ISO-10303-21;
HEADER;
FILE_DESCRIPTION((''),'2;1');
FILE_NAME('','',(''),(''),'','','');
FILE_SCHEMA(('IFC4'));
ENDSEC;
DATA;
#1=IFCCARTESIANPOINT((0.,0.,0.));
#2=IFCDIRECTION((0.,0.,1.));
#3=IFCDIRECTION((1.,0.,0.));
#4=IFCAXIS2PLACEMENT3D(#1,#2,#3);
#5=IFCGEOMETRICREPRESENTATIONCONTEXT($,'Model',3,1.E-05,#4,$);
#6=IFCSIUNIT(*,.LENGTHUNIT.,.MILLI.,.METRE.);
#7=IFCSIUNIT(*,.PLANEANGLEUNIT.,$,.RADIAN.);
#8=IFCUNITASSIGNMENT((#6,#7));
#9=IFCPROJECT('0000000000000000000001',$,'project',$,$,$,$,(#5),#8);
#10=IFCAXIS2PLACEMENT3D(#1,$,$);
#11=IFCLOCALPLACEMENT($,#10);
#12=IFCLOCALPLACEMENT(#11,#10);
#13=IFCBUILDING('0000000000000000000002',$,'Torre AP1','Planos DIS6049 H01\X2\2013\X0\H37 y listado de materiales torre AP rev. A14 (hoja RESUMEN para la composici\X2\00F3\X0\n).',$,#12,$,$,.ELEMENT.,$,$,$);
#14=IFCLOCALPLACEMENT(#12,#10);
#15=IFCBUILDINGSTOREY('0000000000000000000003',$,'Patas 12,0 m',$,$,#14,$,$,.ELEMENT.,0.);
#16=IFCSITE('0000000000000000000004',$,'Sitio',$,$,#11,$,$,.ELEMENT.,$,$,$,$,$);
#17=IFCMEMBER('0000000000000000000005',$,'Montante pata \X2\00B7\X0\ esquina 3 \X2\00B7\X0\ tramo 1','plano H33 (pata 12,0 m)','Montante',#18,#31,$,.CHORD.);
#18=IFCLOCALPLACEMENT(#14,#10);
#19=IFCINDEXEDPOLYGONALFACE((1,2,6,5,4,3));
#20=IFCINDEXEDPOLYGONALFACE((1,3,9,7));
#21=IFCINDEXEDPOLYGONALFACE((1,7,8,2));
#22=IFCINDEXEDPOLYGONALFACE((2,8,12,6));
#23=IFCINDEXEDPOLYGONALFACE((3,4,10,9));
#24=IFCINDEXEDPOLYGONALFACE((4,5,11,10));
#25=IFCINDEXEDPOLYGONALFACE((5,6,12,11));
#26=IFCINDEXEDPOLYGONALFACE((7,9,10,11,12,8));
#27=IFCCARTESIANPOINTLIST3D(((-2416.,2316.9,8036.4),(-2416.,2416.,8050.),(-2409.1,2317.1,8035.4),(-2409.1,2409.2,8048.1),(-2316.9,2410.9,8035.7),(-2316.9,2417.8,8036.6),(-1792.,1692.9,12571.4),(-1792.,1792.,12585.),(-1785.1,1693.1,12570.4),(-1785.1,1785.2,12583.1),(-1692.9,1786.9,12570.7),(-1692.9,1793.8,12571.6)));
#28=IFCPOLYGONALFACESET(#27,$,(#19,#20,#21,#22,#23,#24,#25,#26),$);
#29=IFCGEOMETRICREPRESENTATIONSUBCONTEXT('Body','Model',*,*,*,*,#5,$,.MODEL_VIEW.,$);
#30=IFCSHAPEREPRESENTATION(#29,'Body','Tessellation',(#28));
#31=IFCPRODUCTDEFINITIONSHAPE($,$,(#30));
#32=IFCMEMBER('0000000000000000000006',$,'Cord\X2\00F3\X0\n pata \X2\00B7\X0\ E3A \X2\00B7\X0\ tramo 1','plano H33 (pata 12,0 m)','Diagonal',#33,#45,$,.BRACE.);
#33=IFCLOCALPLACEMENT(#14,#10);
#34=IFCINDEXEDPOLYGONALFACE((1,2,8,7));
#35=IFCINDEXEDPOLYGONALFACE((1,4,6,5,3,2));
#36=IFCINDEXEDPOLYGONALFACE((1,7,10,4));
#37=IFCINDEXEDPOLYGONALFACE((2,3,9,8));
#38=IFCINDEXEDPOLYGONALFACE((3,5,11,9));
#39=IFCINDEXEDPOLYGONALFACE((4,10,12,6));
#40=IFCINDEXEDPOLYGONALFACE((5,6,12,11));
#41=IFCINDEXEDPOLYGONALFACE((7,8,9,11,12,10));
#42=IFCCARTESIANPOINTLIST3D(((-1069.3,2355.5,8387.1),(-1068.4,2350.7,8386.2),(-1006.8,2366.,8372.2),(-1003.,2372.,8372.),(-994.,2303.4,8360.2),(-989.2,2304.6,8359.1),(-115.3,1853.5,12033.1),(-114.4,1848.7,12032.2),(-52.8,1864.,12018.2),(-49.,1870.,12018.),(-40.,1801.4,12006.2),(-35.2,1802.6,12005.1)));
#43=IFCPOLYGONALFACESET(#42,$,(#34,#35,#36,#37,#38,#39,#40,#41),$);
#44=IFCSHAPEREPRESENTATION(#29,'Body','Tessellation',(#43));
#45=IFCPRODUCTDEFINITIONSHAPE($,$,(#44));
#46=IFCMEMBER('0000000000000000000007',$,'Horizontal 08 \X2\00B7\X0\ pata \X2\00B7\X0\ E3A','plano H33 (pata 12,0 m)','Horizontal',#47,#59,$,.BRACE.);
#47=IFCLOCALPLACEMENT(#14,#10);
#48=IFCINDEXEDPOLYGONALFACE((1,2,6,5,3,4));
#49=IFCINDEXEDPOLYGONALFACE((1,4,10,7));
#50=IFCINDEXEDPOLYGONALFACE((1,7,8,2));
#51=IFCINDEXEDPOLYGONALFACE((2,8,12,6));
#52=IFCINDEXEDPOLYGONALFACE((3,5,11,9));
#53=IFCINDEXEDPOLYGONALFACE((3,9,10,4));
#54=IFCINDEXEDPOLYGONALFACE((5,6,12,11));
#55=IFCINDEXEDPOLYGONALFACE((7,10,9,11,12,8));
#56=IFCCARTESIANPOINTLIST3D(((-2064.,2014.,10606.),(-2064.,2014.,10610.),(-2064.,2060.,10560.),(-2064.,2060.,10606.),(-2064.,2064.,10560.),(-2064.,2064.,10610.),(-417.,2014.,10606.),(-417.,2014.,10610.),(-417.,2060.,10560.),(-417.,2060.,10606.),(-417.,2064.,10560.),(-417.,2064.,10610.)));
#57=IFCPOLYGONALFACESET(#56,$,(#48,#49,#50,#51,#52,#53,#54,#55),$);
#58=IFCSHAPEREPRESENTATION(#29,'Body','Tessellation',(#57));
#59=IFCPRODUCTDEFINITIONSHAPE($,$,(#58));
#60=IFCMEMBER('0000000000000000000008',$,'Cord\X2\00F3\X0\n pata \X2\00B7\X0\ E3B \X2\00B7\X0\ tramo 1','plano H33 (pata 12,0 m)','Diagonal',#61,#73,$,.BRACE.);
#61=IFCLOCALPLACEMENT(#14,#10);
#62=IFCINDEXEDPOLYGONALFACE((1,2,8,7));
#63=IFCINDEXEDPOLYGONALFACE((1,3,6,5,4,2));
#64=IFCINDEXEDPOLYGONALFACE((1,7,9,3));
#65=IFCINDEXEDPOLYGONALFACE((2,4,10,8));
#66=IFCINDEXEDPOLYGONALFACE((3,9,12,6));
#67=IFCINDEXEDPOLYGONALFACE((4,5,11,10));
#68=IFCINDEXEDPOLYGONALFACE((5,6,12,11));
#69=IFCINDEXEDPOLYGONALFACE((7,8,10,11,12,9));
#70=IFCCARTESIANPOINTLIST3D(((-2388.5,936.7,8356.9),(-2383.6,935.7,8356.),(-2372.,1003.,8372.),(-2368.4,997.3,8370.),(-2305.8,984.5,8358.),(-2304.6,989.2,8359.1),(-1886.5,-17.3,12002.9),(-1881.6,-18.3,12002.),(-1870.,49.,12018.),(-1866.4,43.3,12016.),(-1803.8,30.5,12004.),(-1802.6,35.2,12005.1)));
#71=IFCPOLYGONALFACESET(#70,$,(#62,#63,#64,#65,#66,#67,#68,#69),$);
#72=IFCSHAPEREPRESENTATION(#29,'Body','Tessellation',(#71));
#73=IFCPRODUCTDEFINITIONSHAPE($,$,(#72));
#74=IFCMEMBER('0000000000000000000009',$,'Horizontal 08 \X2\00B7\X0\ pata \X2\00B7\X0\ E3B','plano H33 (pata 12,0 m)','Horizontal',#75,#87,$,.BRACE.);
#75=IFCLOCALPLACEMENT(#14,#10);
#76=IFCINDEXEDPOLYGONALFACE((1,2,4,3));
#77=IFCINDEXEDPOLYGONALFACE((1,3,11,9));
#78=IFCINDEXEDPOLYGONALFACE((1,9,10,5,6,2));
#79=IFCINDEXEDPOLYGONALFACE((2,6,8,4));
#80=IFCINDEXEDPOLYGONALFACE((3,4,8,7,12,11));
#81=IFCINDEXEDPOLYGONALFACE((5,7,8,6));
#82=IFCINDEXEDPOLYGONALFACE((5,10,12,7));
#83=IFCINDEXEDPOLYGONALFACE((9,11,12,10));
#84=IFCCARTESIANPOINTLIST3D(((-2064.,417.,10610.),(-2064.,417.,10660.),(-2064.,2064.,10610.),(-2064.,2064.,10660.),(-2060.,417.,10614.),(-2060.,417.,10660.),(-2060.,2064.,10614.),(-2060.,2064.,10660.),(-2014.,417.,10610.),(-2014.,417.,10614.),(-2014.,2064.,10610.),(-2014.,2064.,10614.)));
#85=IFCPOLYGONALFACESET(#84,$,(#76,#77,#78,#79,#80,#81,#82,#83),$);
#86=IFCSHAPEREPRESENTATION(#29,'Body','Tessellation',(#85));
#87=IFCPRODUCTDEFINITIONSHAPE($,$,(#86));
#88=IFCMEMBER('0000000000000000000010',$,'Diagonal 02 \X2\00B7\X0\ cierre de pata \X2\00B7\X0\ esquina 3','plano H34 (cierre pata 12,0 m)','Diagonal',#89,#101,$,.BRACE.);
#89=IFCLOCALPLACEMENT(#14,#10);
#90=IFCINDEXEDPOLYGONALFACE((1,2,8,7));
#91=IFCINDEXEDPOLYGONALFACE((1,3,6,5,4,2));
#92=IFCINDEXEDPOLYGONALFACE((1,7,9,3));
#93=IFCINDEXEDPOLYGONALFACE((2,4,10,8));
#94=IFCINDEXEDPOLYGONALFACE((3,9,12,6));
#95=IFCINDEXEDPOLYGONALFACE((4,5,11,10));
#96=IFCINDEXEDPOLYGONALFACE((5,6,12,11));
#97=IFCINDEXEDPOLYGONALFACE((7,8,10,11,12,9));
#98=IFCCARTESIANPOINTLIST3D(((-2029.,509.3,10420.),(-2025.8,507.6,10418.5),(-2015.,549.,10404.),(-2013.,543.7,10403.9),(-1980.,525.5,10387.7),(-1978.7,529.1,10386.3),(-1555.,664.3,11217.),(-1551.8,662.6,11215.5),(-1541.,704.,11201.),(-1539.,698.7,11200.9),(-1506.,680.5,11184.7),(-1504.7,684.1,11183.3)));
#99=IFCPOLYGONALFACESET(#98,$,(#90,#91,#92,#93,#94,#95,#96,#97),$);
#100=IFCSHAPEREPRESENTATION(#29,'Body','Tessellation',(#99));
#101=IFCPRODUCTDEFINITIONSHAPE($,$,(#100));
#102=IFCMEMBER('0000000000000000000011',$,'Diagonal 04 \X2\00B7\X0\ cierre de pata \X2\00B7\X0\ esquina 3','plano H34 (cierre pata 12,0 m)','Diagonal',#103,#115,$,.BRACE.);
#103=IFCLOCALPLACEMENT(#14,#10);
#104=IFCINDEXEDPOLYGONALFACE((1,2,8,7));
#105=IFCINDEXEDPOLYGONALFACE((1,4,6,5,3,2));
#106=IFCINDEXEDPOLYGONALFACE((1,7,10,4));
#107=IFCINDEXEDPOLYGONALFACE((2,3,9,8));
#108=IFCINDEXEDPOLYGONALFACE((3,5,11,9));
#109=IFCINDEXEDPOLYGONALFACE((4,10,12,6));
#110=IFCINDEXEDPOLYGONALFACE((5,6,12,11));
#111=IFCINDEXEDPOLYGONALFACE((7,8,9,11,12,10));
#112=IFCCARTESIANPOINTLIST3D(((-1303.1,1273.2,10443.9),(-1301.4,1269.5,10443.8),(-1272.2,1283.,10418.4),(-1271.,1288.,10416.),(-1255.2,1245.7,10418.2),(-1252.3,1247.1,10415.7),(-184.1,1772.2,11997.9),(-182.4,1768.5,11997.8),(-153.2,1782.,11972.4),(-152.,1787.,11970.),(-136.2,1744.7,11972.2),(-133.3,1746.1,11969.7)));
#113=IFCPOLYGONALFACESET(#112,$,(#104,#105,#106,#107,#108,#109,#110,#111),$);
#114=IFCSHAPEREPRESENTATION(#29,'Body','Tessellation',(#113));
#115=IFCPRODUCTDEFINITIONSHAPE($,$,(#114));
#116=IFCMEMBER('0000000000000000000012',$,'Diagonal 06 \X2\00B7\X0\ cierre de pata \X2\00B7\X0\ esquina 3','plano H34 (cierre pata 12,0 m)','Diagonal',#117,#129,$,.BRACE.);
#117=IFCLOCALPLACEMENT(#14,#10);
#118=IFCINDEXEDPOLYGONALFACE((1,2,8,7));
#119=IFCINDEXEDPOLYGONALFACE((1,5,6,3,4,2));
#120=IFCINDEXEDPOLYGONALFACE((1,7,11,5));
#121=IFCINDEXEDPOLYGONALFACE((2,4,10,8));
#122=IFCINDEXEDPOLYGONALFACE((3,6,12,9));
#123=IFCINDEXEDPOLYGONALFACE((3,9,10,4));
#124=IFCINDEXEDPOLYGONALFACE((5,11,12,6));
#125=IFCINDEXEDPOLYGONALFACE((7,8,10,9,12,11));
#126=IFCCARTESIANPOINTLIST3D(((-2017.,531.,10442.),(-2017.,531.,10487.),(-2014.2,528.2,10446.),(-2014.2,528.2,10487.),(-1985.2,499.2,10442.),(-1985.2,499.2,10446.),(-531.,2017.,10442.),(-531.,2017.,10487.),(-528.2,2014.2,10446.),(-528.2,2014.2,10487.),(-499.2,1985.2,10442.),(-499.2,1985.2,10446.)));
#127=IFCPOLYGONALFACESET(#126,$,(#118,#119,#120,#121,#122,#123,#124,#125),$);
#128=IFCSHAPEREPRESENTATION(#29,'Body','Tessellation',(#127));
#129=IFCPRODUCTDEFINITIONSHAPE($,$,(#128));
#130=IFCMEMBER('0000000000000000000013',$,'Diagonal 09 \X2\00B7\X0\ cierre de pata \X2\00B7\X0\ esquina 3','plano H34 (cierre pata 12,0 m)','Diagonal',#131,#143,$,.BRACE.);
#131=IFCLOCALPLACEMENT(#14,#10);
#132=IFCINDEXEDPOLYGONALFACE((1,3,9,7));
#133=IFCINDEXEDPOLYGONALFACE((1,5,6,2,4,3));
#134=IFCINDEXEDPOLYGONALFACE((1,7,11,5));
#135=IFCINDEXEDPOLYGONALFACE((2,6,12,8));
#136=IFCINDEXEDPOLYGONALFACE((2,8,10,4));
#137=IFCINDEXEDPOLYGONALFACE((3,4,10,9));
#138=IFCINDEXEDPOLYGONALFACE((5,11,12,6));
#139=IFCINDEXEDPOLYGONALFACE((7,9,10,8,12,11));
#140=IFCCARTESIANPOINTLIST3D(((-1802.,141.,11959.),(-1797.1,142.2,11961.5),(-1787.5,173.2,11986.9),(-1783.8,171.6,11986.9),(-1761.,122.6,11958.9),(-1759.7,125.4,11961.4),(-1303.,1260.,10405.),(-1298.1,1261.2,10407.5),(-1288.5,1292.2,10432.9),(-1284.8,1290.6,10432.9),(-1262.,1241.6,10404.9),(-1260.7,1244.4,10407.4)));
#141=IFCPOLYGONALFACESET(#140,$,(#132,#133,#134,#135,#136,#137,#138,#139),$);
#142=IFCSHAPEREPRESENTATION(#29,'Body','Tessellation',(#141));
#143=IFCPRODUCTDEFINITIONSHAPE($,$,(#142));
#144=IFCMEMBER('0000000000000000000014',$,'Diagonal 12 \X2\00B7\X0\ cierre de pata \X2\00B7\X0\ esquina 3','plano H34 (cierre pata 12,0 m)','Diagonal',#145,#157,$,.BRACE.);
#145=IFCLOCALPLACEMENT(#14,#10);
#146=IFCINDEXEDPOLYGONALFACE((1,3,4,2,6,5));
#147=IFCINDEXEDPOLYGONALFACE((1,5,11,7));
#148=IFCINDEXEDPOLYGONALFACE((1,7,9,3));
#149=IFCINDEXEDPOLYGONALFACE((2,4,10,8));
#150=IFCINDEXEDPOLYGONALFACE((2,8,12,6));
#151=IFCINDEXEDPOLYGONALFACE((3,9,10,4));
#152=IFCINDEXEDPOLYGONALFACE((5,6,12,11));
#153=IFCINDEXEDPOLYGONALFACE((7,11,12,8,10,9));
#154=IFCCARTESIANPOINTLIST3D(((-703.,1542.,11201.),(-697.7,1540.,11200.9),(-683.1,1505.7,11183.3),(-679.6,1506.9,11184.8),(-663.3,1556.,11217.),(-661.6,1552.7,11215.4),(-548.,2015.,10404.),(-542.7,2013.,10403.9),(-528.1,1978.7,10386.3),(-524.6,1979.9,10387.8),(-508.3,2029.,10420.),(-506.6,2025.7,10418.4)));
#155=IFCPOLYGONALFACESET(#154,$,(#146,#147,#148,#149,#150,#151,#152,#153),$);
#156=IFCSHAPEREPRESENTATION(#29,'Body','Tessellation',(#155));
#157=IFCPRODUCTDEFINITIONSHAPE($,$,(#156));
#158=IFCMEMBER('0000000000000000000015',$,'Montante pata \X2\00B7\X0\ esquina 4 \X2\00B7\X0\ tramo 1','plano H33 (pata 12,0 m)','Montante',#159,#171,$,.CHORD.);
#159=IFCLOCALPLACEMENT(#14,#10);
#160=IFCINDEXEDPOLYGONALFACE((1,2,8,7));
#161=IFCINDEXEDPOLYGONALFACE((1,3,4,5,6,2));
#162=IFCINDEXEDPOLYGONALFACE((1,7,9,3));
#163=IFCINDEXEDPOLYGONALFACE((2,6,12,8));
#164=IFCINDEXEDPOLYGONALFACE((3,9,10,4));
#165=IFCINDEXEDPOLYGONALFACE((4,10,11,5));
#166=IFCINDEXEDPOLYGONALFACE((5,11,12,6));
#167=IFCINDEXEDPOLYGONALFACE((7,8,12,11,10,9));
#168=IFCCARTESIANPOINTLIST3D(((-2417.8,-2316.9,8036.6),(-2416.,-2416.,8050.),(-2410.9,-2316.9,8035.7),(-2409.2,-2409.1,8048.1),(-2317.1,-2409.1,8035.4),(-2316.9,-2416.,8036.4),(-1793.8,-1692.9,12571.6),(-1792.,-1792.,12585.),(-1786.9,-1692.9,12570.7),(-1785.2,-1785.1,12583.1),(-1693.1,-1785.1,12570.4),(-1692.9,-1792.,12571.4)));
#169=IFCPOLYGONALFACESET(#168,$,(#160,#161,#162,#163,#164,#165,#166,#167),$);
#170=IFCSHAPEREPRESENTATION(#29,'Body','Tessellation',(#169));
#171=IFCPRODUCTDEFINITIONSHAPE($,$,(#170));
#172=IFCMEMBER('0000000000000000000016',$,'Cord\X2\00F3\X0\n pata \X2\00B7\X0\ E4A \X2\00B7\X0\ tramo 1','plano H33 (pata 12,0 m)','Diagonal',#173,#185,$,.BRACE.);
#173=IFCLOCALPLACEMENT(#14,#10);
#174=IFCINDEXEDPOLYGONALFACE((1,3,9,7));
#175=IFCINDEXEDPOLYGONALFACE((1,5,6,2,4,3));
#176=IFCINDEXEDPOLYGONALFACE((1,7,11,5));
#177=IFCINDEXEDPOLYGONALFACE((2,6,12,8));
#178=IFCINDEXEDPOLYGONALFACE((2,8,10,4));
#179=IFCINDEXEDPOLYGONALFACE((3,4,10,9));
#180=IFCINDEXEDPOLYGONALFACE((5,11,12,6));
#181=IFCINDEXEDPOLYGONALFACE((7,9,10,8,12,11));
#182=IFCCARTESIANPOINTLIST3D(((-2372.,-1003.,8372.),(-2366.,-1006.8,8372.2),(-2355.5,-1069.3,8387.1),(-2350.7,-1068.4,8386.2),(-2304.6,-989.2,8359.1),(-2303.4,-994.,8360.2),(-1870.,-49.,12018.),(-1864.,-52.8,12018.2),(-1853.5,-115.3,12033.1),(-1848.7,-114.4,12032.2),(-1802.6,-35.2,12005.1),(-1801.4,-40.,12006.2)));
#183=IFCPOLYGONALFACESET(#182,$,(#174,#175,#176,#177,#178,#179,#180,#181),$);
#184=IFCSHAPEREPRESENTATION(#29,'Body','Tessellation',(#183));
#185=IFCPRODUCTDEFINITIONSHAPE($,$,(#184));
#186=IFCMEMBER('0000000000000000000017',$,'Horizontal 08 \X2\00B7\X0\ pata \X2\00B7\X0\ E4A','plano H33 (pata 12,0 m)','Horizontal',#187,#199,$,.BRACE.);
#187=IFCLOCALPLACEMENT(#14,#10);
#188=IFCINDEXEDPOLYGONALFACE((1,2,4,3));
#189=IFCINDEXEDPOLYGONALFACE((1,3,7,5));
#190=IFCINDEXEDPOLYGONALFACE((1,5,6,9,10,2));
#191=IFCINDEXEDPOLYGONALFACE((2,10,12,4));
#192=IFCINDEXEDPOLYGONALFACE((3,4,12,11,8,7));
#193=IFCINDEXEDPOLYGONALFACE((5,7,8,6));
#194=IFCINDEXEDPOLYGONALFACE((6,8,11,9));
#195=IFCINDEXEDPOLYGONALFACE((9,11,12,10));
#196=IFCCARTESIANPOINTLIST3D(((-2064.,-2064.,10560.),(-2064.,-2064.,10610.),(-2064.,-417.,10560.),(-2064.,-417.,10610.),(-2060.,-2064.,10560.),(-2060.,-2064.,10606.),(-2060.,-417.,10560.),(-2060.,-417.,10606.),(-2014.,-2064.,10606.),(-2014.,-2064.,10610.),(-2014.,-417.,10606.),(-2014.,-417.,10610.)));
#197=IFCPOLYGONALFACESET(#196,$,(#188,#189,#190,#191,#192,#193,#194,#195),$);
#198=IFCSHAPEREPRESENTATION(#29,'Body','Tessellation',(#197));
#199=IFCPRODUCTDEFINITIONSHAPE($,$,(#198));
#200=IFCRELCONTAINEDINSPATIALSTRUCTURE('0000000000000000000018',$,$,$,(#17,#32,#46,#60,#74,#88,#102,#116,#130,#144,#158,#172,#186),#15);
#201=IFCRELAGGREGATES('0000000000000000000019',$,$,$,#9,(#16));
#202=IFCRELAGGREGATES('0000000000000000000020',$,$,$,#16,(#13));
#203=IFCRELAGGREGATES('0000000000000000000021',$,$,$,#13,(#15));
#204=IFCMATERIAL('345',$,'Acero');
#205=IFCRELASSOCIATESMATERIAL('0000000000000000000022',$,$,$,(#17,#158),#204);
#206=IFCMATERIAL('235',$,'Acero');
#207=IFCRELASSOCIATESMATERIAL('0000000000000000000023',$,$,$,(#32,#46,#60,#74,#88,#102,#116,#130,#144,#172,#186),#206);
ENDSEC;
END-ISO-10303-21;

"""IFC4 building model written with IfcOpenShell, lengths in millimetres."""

from ifc_helpers import new_model, si_unit, frame, frame_2d, origin, origin_with_axes, place, context, subcontext, project, spatial, l_section, extrude, material, element, save


model = new_model("IFC4")

# Units and contexts
model_context = context("Model", 3, precision=1e-05, world=origin_with_axes())
body_context = subcontext(model_context, "Body", "Model", "MODEL_VIEW")
ifc_project = project(units=[si_unit("LENGTHUNIT", "METRE", prefix="MILLI"), si_unit("PLANEANGLEUNIT", "RADIAN")], contexts=[model_context])

# Site, building, storey
site_placement = place(None, origin())
site = spatial("IfcSite", under=ifc_project, at=site_placement, Name="Sitio", CompositionType="ELEMENT")
building_placement = place(site_placement, origin())
building = spatial("IfcBuilding", under=site, at=building_placement, Name="Torre AP1", Description="Planos DIS6049 H01–H37 y listado de materiales torre AP rev. A14 (hoja RESUMEN para la composición).", CompositionType="ELEMENT")
storey_placement = place(building_placement, origin())
storey = spatial("IfcBuildingStorey", under=building, at=storey_placement, Name="Patas 12,0 m", CompositionType="ELEMENT", Elevation=0.0)

# Members
ifc_material_1 = material(Name="345", Category="Acero")
member_1_placement = place(storey_placement, frame((-1792.0, 1792.0, 12585.0), z_axis=(-0.135063, 0.135063, -0.981588), x_axis=(0.990837, 0.018411, -0.133802)))
element("IfcMember", 1, at=member_1_placement, inside=storey, material=ifc_material_1, Name="Montante pata · esquina 3 · tramo 1", Description="plano H33 (pata 12,0 m)", ObjectType="Montante", PredefinedType="CHORD", context=body_context, shape_type="SweptSolid", body=[
    extrude(l_section(Depth=100.0, Width=100.0, Thickness=7.0, at=frame_2d((50.0, 50.0))), None, (0.0, 0.0, 1.0), 4620.1),
])
ifc_material_2 = material(Name="235", Category="Acero")
member_2_placement = place(storey_placement, frame((-49.0, 1870.0, 12018.0), z_axis=(-0.250919, 0.132035, -0.958961), x_axis=(0.196926, -0.962976, -0.184114)))
element("IfcMember", 2, at=member_2_placement, inside=storey, material=ifc_material_2, Name="Cordón pata · E3A · tramo 1", Description="plano H33 (pata 12,0 m)", ObjectType="Diagonal", PredefinedType="BRACE", context=body_context, shape_type="SweptSolid", body=[
    extrude(l_section(Depth=70.0, Width=70.0, Thickness=5.0, at=frame_2d((35.0, 35.0))), None, (0.0, 0.0, 1.0), 3802.0),
])
member_3_placement = place(storey_placement, frame((-2064.0, 2064.0, 10610.0), z_axis=(1.0, 0.0, 0.0), x_axis=(0.0, -1.0, 0.0)))
element("IfcMember", 3, at=member_3_placement, inside=storey, material=ifc_material_2, Name="Horizontal 08 · pata · E3A", Description="plano H33 (pata 12,0 m)", ObjectType="Horizontal", PredefinedType="BRACE", context=body_context, shape_type="SweptSolid", body=[
    extrude(l_section(Depth=50.0, Width=50.0, Thickness=4.0, at=frame_2d((25.0, 25.0))), None, (0.0, 0.0, 1.0), 1647.0),
])
member_4_placement = place(storey_placement, frame((-1870.0, 49.0, 12018.0), z_axis=(-0.132035, 0.250919, -0.958961), x_axis=(0.962976, -0.196926, -0.184114)))
element("IfcMember", 4, at=member_4_placement, inside=storey, material=ifc_material_2, Name="Cordón pata · E3B · tramo 1", Description="plano H33 (pata 12,0 m)", ObjectType="Diagonal", PredefinedType="BRACE", context=body_context, shape_type="SweptSolid", body=[
    extrude(l_section(Depth=70.0, Width=70.0, Thickness=5.0, at=frame_2d((35.0, 35.0))), None, (0.0, 0.0, 1.0), 3802.0),
])
member_5_placement = place(storey_placement, frame((-2064.0, 2064.0, 10610.0), z_axis=(0.0, -1.0, 0.0), x_axis=(1.0, 0.0, 0.0)))
element("IfcMember", 5, at=member_5_placement, inside=storey, material=ifc_material_2, Name="Horizontal 08 · pata · E3B", Description="plano H33 (pata 12,0 m)", ObjectType="Horizontal", PredefinedType="BRACE", context=body_context, shape_type="SweptSolid", body=[
    extrude(l_section(Depth=50.0, Width=50.0, Thickness=4.0, at=frame_2d((25.0, 25.0))), None, (0.0, 0.0, 1.0), 1647.0),
])
member_6_placement = place(storey_placement, frame((-1541.0, 704.0, 11201.0), z_axis=(-0.504167, -0.164865, -0.847724), x_axis=(0.805838, -0.442792, -0.393142)))
element("IfcMember", 6, at=member_6_placement, inside=storey, material=ifc_material_2, Name="Diagonal 02 · cierre de pata · esquina 3", Description="plano H34 (cierre pata 12,0 m)", ObjectType="Diagonal", PredefinedType="BRACE", context=body_context, shape_type="SweptSolid", body=[
    extrude(l_section(Depth=45.0, Width=45.0, Thickness=4.0, at=frame_2d((22.5, 22.5))), None, (0.0, 0.0, 1.0), 940.2),
])
member_7_placement = place(storey_placement, frame((-152.0, 1787.0, 11970.0), z_axis=(-0.565463, -0.252159, -0.785281), x_axis=(0.415107, -0.909747, -0.006783)))
element("IfcMember", 7, at=member_7_placement, inside=storey, material=ifc_material_2, Name="Diagonal 04 · cierre de pata · esquina 3", Description="plano H34 (cierre pata 12,0 m)", ObjectType="Diagonal", PredefinedType="BRACE", context=body_context, shape_type="SweptSolid", body=[
    extrude(l_section(Depth=45.0, Width=45.0, Thickness=4.0, at=frame_2d((22.5, 22.5))), None, (0.0, 0.0, 1.0), 1978.9),
])
member_8_placement = place(storey_placement, frame((-531.0, 2017.0, 10442.0), z_axis=(-0.707107, -0.707107, 0.0), x_axis=(0.707107, -0.707107, 0.0)))
element("IfcMember", 8, at=member_8_placement, inside=storey, material=ifc_material_2, Name="Diagonal 06 · cierre de pata · esquina 3", Description="plano H34 (cierre pata 12,0 m)", ObjectType="Diagonal", PredefinedType="BRACE", context=body_context, shape_type="SweptSolid", body=[
    extrude(l_section(Depth=45.0, Width=45.0, Thickness=4.0, at=frame_2d((22.5, 22.5))), None, (0.0, 0.0, 1.0), 2101.5),
])
member_9_placement = place(storey_placement, frame((-1303.0, 1260.0, 10405.0), z_axis=(-0.252159, -0.565463, 0.785281), x_axis=(0.912198, -0.409744, -0.002135)))
element("IfcMember", 9, at=member_9_placement, inside=storey, material=ifc_material_2, Name="Diagonal 09 · cierre de pata · esquina 3", Description="plano H34 (cierre pata 12,0 m)", ObjectType="Diagonal", PredefinedType="BRACE", context=body_context, shape_type="SweptSolid", body=[
    extrude(l_section(Depth=45.0, Width=45.0, Thickness=4.0, at=frame_2d((22.5, 22.5))), None, (0.0, 0.0, 1.0), 1978.9),
])
member_10_placement = place(storey_placement, frame((-548.0, 2015.0, 10404.0), z_axis=(-0.164953, -0.503373, 0.848178), x_axis=(0.441981, -0.806505, -0.392685)))
element("IfcMember", 10, at=member_10_placement, inside=storey, material=ifc_material_2, Name="Diagonal 12 · cierre de pata · esquina 3", Description="plano H34 (cierre pata 12,0 m)", ObjectType="Diagonal", PredefinedType="BRACE", context=body_context, shape_type="SweptSolid", body=[
    extrude(l_section(Depth=45.0, Width=45.0, Thickness=4.0, at=frame_2d((22.5, 22.5))), None, (0.0, 0.0, 1.0), 939.7),
])
member_11_placement = place(storey_placement, frame((-1792.0, -1792.0, 12585.0), z_axis=(-0.135063, -0.135063, -0.981588), x_axis=(-0.018411, 0.990837, -0.133802)))
element("IfcMember", 11, at=member_11_placement, inside=storey, material=ifc_material_1, Name="Montante pata · esquina 4 · tramo 1", Description="plano H33 (pata 12,0 m)", ObjectType="Montante", PredefinedType="CHORD", context=body_context, shape_type="SweptSolid", body=[
    extrude(l_section(Depth=100.0, Width=100.0, Thickness=7.0, at=frame_2d((50.0, 50.0))), None, (0.0, 0.0, 1.0), 4620.1),
])
member_12_placement = place(storey_placement, frame((-1870.0, -49.0, 12018.0), z_axis=(-0.132035, -0.250919, -0.958961), x_axis=(0.962976, 0.196926, -0.184114)))
element("IfcMember", 12, at=member_12_placement, inside=storey, material=ifc_material_2, Name="Cordón pata · E4A · tramo 1", Description="plano H33 (pata 12,0 m)", ObjectType="Diagonal", PredefinedType="BRACE", context=body_context, shape_type="SweptSolid", body=[
    extrude(l_section(Depth=70.0, Width=70.0, Thickness=5.0, at=frame_2d((35.0, 35.0))), None, (0.0, 0.0, 1.0), 3802.0),
])
for number, where, z_axis, x_axis, name in (
    (13, (-2064.0, -2064.0, 10610.0), (0.0, 1.0, 0.0), (1.0, 0.0, 0.0), "Horizontal 08 · pata · E4A"),
):
    element("IfcMember", number, at=place(storey_placement, frame(where, z_axis=z_axis, x_axis=x_axis)), inside=storey, material=ifc_material_2, Name=name, Description="plano H33 (pata 12,0 m)", ObjectType="Horizontal", PredefinedType="BRACE", context=body_context, shape_type="SweptSolid", body=[
        extrude(l_section(Depth=50.0, Width=50.0, Thickness=4.0, at=frame_2d((25.0, 25.0))), None, (0.0, 0.0, 1.0), 1647.0),
    ])

save(model, "model.ifc")
